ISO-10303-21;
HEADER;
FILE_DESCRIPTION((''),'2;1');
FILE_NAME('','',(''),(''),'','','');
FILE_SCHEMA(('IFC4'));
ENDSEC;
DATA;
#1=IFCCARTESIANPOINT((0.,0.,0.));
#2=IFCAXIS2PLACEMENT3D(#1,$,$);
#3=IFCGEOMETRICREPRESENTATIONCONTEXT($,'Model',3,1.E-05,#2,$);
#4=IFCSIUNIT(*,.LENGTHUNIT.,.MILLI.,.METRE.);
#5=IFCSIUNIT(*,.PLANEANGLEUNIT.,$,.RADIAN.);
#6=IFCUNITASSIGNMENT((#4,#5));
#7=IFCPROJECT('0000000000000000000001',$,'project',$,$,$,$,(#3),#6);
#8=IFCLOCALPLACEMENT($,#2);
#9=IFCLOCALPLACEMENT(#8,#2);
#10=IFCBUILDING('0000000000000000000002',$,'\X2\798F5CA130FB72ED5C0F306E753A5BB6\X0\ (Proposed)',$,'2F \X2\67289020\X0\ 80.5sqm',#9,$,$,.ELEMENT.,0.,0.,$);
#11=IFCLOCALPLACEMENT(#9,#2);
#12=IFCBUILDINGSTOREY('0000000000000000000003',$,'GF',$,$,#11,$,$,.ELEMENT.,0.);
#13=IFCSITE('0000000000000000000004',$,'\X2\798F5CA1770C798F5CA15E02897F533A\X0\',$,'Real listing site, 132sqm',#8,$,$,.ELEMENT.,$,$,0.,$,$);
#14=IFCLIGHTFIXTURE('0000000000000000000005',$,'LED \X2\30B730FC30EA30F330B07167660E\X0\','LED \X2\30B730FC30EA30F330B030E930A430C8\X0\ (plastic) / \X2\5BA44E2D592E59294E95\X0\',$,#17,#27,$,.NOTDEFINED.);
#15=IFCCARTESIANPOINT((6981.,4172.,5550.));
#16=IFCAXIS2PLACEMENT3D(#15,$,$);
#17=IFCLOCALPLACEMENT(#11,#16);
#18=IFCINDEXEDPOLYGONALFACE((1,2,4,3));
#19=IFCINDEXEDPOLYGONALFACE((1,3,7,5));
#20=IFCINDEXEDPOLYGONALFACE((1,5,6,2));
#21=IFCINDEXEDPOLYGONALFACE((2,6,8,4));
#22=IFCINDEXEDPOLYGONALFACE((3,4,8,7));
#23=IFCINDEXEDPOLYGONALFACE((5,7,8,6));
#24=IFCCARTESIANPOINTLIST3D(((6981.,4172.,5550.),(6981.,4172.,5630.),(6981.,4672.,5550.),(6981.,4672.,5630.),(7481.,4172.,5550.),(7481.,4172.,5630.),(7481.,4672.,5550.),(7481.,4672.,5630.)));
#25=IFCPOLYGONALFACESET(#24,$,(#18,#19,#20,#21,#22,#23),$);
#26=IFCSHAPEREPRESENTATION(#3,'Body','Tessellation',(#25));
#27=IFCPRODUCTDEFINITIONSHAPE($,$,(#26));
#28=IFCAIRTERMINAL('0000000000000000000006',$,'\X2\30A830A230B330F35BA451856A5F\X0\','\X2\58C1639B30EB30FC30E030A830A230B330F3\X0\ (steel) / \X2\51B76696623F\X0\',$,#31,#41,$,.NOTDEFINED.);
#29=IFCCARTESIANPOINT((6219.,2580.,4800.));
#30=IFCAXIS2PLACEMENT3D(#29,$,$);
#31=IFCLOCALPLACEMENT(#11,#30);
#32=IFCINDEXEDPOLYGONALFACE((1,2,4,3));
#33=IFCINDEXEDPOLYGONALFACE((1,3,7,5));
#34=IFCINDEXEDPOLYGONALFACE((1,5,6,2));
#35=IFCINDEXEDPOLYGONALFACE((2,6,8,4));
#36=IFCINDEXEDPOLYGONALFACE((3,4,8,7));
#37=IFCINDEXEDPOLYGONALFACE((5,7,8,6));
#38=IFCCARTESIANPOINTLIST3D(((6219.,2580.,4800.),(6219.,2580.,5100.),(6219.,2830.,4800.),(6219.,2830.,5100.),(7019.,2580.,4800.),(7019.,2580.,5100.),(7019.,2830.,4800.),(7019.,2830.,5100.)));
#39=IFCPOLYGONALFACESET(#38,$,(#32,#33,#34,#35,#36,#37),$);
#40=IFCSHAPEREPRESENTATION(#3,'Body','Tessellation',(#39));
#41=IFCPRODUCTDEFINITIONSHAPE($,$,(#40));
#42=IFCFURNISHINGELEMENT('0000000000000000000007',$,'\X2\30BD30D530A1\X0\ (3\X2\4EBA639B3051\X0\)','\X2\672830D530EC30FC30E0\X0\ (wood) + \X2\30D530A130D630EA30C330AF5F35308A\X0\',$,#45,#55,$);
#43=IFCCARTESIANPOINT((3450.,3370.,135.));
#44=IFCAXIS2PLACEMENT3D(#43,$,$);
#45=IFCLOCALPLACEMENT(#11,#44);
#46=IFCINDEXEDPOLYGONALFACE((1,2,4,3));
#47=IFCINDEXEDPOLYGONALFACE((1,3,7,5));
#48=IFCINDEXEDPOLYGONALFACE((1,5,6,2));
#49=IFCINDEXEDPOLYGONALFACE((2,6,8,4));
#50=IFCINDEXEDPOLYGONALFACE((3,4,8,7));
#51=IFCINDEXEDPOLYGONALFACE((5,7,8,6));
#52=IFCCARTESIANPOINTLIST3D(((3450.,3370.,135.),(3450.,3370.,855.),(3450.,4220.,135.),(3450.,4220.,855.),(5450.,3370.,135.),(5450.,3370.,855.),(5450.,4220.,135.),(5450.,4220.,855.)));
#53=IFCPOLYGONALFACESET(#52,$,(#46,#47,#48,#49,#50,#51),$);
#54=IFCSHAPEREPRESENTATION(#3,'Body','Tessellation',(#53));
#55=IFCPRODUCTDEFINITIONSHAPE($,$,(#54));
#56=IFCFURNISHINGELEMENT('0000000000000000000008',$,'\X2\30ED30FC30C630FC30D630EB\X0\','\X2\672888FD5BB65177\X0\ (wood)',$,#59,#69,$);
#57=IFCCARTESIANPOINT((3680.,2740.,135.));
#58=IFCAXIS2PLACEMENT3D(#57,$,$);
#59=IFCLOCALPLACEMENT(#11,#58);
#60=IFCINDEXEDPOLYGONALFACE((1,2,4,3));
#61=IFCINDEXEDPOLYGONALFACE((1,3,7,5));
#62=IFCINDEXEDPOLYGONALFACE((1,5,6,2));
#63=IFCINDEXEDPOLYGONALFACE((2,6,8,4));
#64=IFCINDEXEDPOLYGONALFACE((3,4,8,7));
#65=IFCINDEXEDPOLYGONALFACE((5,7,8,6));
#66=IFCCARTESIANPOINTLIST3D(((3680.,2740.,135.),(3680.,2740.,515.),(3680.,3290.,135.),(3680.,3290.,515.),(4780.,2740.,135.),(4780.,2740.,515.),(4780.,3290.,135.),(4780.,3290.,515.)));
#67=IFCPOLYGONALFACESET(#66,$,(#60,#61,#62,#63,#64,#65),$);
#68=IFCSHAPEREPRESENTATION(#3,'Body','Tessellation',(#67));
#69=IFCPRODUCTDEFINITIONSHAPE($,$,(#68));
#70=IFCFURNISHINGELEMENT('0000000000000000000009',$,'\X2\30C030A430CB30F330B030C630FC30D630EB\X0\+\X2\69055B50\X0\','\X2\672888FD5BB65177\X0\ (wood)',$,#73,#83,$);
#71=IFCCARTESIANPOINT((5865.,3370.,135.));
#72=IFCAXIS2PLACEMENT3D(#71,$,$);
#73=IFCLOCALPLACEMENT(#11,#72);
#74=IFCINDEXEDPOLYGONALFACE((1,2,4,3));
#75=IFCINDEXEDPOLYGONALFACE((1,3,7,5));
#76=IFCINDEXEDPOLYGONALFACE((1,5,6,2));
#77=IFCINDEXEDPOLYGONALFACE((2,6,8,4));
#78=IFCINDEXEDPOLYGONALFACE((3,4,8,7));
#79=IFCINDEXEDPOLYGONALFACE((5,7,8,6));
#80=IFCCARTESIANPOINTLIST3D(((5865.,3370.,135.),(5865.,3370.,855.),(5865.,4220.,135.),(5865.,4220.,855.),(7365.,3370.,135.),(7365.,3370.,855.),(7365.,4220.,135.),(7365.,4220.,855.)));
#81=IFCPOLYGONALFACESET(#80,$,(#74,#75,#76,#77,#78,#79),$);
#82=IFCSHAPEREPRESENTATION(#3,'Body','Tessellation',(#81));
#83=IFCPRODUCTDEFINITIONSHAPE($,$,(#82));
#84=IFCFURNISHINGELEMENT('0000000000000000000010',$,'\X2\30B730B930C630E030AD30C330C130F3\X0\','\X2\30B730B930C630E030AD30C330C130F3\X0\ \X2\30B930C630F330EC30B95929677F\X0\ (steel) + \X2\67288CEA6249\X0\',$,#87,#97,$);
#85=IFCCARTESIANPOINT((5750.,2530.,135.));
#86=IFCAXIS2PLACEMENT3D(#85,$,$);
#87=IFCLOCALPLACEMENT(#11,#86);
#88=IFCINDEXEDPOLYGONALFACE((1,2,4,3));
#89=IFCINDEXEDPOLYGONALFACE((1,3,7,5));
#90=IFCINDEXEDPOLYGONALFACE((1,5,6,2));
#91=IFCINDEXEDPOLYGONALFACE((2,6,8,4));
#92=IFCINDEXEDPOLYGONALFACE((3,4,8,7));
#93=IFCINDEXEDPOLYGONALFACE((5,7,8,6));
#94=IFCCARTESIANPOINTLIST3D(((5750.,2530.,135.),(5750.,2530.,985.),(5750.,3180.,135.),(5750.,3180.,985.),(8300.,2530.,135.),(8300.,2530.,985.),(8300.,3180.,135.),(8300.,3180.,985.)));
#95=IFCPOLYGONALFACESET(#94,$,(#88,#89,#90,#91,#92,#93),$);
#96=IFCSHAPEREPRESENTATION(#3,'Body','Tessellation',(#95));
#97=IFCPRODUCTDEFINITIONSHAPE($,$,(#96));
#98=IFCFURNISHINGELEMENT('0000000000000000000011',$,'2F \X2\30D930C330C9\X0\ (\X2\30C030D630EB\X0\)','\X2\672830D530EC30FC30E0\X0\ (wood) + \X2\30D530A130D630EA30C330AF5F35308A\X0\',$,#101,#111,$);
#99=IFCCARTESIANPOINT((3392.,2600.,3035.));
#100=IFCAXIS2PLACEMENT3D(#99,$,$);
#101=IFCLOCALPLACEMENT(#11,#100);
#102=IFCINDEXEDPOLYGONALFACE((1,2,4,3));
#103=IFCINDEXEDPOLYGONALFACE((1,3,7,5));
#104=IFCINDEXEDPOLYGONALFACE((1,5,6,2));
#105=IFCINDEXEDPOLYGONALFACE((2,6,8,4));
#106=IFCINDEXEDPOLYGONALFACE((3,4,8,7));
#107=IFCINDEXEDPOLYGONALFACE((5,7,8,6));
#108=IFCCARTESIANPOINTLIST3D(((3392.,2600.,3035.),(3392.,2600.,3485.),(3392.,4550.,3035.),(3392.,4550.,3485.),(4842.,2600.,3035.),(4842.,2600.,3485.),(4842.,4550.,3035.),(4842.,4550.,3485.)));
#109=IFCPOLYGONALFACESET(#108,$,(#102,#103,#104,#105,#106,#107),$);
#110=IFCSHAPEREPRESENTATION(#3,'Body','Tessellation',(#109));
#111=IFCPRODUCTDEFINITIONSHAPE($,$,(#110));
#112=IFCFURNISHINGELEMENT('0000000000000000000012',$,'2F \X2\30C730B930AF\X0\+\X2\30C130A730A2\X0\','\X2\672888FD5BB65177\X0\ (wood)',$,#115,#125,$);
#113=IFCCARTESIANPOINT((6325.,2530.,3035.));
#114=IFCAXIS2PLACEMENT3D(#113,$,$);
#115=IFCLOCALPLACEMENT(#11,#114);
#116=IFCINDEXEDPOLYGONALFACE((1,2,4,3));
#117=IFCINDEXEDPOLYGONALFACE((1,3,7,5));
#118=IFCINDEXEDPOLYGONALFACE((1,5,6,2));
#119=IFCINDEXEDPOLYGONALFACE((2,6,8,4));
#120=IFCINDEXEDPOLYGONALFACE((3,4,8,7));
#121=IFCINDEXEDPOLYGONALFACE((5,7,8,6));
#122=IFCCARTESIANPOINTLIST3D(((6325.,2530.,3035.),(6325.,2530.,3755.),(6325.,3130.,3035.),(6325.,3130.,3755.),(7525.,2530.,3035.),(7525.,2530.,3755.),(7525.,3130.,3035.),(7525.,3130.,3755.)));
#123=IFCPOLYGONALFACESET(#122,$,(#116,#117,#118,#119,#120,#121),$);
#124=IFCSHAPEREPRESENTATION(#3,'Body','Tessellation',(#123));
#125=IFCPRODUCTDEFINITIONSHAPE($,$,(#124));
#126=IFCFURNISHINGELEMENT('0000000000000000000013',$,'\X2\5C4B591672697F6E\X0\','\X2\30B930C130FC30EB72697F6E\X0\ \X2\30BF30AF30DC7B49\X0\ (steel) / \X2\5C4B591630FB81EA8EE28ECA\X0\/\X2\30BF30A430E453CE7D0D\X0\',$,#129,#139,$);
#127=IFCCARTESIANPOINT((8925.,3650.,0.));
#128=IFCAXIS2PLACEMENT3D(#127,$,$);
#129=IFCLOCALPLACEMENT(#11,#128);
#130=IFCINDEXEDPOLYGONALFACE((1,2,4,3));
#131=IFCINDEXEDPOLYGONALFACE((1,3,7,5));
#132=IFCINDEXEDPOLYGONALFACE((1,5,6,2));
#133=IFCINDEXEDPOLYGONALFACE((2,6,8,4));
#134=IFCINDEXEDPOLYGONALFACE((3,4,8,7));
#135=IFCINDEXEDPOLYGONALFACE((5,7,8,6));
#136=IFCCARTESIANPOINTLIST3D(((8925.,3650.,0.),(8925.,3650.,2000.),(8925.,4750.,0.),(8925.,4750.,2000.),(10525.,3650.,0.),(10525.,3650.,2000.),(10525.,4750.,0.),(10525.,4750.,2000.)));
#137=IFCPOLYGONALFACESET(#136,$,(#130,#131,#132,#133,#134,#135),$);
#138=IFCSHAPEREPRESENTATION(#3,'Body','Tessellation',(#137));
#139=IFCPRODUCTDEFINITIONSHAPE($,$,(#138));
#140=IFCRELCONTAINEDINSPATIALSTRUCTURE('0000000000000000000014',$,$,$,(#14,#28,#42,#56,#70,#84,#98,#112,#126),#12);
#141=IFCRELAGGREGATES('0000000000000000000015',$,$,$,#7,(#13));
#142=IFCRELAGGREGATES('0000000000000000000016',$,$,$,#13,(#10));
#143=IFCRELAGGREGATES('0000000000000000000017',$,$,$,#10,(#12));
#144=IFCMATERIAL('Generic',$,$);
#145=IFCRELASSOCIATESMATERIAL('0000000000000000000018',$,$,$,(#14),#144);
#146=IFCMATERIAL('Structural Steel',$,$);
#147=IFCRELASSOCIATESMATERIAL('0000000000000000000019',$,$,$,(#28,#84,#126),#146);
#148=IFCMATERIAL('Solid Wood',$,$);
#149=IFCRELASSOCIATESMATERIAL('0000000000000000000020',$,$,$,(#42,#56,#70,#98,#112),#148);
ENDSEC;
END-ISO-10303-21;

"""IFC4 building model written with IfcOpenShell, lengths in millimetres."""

from ifc_helpers import new_model, si_unit, frame, frame_2d, origin, place, context, project, spatial, rectangle, extrude, material, element, save


model = new_model("IFC4")

# Units and contexts
model_context = context("Model", 3, precision=1e-05, world=origin())
ifc_project = project(units=[si_unit("LENGTHUNIT", "METRE", prefix="MILLI"), si_unit("PLANEANGLEUNIT", "RADIAN")], contexts=[model_context])

# Site, building, storey
site_placement = place(None, origin())
site = spatial("IfcSite", under=ifc_project, at=site_placement, Name="福岡県福岡市西区", ObjectType="Real listing site, 132sqm", CompositionType="ELEMENT", RefElevation=0.0)
building_placement = place(site_placement, origin())
building = spatial("IfcBuilding", under=site, at=building_placement, Name="福岡・狭小の町家 (Proposed)", ObjectType="2F 木造 80.5sqm", CompositionType="ELEMENT", ElevationOfRefHeight=0.0, ElevationOfTerrain=0.0)
storey_placement = place(building_placement, origin())
storey = spatial("IfcBuildingStorey", under=building, at=storey_placement, Name="GF", CompositionType="ELEMENT", Elevation=0.0)

# Shared definitions
ifc_material_1 = material(Name="Solid Wood")

# Shared definitions
ifc_material_2 = material(Name="Generic")

# Shared definitions
ifc_material_3 = material(Name="Structural Steel")

# Light fixture
light_fixture_placement = place(storey_placement, frame((6981.0, 4172.0, 5550.0)))
element("IfcLightFixture", 1, at=light_fixture_placement, inside=storey, material=ifc_material_2, Name="LED シーリング照明", Description="LED シーリングライト (plastic) / 室中央天井", PredefinedType="NOTDEFINED", context=model_context, shape_type="SweptSolid", body=[
    extrude(rectangle(XDim=500.0, YDim=500.0, at=frame_2d((250.0, 250.0))), frame((6981.0, 4172.0, 5550.0)), (0.0, 0.0, 1.0), 80.0),
])

# Air terminal
air_terminal_1_placement = place(storey_placement, frame((6219.0, 2580.0, 4800.0)))
element("IfcAirTerminal", 2, at=air_terminal_1_placement, inside=storey, material=ifc_material_3, Name="エアコン室内機", Description="壁掛ルームエアコン (steel) / 冷暖房", PredefinedType="NOTDEFINED", context=model_context, shape_type="SweptSolid", body=[
    extrude(rectangle(XDim=800.0, YDim=250.0, at=frame_2d((400.0, 125.0))), frame((6219.0, 2580.0, 4800.0)), (0.0, 0.0, 1.0), 300.0),
])

# Furnishing elements
furnishing_1_placement = place(storey_placement, frame((3450.0, 3370.0, 135.0)))
element("IfcFurnishingElement", 3, at=furnishing_1_placement, inside=storey, material=ifc_material_1, Name="ソファ (3人掛け)", Description="木フレーム (wood) + ファブリック張り", context=model_context, shape_type="SweptSolid", body=[
    extrude(rectangle(XDim=2000.0, YDim=850.0, at=frame_2d((1000.0, 425.0))), frame((3450.0, 3370.0, 135.0)), (0.0, 0.0, 1.0), 720.0),
])
furnishing_2_placement = place(storey_placement, frame((3680.0, 2740.0, 135.0)))
element("IfcFurnishingElement", 4, at=furnishing_2_placement, inside=storey, material=ifc_material_1, Name="ローテーブル", Description="木製家具 (wood)", context=model_context, shape_type="SweptSolid", body=[
    extrude(rectangle(XDim=1100.0, YDim=550.0, at=frame_2d((550.0, 275.0))), frame((3680.0, 2740.0, 135.0)), (0.0, 0.0, 1.0), 380.0),
])
furnishing_3_placement = place(storey_placement, frame((5865.0, 3370.0, 135.0)))
element("IfcFurnishingElement", 5, at=furnishing_3_placement, inside=storey, material=ifc_material_1, Name="ダイニングテーブル+椅子", Description="木製家具 (wood)", context=model_context, shape_type="SweptSolid", body=[
    extrude(rectangle(XDim=1500.0, YDim=850.0, at=frame_2d((750.0, 425.0))), frame((5865.0, 3370.0, 135.0)), (0.0, 0.0, 1.0), 720.0),
])
furnishing_4_placement = place(storey_placement, frame((5750.0, 2530.0, 135.0)))
element("IfcFurnishingElement", 6, at=furnishing_4_placement, inside=storey, material=ifc_material_3, Name="システムキッチン", Description="システムキッチン ステンレス天板 (steel) + 木質扉", context=model_context, shape_type="SweptSolid", body=[
    extrude(rectangle(XDim=2550.0, YDim=650.0, at=frame_2d((1275.0, 325.0))), frame((5750.0, 2530.0, 135.0)), (0.0, 0.0, 1.0), 850.0),
])
furnishing_5_placement = place(storey_placement, frame((3392.0, 2600.0, 3035.0)))
element("IfcFurnishingElement", 7, at=furnishing_5_placement, inside=storey, material=ifc_material_1, Name="2F ベッド (ダブル)", Description="木フレーム (wood) + ファブリック張り", context=model_context, shape_type="SweptSolid", body=[
    extrude(rectangle(XDim=1450.0, YDim=1950.0, at=frame_2d((725.0, 975.0))), frame((3392.0, 2600.0, 3035.0)), (0.0, 0.0, 1.0), 450.0),
])
furnishing_6_placement = place(storey_placement, frame((6325.0, 2530.0, 3035.0)))
element("IfcFurnishingElement", 8, at=furnishing_6_placement, inside=storey, material=ifc_material_1, Name="2F デスク+チェア", Description="木製家具 (wood)", context=model_context, shape_type="SweptSolid", body=[
    extrude(rectangle(XDim=1200.0, YDim=600.0, at=frame_2d((600.0, 300.0))), frame((6325.0, 2530.0, 3035.0)), (0.0, 0.0, 1.0), 720.0),
])
furnishing_7_placement = place(storey_placement, frame((8925.0, 3650.0, 0.0)))
element("IfcFurnishingElement", 9, at=furnishing_7_placement, inside=storey, material=ifc_material_3, Name="屋外物置", Description="スチール物置 タクボ等 (steel) / 屋外・自転車/タイヤ収納", context=model_context, shape_type="SweptSolid", body=[
    extrude(rectangle(XDim=1600.0, YDim=1100.0, at=frame_2d((800.0, 550.0))), frame((8925.0, 3650.0, 0.0)), (0.0, 0.0, 1.0), 2000.0),
])

save(model, "model.ifc")
